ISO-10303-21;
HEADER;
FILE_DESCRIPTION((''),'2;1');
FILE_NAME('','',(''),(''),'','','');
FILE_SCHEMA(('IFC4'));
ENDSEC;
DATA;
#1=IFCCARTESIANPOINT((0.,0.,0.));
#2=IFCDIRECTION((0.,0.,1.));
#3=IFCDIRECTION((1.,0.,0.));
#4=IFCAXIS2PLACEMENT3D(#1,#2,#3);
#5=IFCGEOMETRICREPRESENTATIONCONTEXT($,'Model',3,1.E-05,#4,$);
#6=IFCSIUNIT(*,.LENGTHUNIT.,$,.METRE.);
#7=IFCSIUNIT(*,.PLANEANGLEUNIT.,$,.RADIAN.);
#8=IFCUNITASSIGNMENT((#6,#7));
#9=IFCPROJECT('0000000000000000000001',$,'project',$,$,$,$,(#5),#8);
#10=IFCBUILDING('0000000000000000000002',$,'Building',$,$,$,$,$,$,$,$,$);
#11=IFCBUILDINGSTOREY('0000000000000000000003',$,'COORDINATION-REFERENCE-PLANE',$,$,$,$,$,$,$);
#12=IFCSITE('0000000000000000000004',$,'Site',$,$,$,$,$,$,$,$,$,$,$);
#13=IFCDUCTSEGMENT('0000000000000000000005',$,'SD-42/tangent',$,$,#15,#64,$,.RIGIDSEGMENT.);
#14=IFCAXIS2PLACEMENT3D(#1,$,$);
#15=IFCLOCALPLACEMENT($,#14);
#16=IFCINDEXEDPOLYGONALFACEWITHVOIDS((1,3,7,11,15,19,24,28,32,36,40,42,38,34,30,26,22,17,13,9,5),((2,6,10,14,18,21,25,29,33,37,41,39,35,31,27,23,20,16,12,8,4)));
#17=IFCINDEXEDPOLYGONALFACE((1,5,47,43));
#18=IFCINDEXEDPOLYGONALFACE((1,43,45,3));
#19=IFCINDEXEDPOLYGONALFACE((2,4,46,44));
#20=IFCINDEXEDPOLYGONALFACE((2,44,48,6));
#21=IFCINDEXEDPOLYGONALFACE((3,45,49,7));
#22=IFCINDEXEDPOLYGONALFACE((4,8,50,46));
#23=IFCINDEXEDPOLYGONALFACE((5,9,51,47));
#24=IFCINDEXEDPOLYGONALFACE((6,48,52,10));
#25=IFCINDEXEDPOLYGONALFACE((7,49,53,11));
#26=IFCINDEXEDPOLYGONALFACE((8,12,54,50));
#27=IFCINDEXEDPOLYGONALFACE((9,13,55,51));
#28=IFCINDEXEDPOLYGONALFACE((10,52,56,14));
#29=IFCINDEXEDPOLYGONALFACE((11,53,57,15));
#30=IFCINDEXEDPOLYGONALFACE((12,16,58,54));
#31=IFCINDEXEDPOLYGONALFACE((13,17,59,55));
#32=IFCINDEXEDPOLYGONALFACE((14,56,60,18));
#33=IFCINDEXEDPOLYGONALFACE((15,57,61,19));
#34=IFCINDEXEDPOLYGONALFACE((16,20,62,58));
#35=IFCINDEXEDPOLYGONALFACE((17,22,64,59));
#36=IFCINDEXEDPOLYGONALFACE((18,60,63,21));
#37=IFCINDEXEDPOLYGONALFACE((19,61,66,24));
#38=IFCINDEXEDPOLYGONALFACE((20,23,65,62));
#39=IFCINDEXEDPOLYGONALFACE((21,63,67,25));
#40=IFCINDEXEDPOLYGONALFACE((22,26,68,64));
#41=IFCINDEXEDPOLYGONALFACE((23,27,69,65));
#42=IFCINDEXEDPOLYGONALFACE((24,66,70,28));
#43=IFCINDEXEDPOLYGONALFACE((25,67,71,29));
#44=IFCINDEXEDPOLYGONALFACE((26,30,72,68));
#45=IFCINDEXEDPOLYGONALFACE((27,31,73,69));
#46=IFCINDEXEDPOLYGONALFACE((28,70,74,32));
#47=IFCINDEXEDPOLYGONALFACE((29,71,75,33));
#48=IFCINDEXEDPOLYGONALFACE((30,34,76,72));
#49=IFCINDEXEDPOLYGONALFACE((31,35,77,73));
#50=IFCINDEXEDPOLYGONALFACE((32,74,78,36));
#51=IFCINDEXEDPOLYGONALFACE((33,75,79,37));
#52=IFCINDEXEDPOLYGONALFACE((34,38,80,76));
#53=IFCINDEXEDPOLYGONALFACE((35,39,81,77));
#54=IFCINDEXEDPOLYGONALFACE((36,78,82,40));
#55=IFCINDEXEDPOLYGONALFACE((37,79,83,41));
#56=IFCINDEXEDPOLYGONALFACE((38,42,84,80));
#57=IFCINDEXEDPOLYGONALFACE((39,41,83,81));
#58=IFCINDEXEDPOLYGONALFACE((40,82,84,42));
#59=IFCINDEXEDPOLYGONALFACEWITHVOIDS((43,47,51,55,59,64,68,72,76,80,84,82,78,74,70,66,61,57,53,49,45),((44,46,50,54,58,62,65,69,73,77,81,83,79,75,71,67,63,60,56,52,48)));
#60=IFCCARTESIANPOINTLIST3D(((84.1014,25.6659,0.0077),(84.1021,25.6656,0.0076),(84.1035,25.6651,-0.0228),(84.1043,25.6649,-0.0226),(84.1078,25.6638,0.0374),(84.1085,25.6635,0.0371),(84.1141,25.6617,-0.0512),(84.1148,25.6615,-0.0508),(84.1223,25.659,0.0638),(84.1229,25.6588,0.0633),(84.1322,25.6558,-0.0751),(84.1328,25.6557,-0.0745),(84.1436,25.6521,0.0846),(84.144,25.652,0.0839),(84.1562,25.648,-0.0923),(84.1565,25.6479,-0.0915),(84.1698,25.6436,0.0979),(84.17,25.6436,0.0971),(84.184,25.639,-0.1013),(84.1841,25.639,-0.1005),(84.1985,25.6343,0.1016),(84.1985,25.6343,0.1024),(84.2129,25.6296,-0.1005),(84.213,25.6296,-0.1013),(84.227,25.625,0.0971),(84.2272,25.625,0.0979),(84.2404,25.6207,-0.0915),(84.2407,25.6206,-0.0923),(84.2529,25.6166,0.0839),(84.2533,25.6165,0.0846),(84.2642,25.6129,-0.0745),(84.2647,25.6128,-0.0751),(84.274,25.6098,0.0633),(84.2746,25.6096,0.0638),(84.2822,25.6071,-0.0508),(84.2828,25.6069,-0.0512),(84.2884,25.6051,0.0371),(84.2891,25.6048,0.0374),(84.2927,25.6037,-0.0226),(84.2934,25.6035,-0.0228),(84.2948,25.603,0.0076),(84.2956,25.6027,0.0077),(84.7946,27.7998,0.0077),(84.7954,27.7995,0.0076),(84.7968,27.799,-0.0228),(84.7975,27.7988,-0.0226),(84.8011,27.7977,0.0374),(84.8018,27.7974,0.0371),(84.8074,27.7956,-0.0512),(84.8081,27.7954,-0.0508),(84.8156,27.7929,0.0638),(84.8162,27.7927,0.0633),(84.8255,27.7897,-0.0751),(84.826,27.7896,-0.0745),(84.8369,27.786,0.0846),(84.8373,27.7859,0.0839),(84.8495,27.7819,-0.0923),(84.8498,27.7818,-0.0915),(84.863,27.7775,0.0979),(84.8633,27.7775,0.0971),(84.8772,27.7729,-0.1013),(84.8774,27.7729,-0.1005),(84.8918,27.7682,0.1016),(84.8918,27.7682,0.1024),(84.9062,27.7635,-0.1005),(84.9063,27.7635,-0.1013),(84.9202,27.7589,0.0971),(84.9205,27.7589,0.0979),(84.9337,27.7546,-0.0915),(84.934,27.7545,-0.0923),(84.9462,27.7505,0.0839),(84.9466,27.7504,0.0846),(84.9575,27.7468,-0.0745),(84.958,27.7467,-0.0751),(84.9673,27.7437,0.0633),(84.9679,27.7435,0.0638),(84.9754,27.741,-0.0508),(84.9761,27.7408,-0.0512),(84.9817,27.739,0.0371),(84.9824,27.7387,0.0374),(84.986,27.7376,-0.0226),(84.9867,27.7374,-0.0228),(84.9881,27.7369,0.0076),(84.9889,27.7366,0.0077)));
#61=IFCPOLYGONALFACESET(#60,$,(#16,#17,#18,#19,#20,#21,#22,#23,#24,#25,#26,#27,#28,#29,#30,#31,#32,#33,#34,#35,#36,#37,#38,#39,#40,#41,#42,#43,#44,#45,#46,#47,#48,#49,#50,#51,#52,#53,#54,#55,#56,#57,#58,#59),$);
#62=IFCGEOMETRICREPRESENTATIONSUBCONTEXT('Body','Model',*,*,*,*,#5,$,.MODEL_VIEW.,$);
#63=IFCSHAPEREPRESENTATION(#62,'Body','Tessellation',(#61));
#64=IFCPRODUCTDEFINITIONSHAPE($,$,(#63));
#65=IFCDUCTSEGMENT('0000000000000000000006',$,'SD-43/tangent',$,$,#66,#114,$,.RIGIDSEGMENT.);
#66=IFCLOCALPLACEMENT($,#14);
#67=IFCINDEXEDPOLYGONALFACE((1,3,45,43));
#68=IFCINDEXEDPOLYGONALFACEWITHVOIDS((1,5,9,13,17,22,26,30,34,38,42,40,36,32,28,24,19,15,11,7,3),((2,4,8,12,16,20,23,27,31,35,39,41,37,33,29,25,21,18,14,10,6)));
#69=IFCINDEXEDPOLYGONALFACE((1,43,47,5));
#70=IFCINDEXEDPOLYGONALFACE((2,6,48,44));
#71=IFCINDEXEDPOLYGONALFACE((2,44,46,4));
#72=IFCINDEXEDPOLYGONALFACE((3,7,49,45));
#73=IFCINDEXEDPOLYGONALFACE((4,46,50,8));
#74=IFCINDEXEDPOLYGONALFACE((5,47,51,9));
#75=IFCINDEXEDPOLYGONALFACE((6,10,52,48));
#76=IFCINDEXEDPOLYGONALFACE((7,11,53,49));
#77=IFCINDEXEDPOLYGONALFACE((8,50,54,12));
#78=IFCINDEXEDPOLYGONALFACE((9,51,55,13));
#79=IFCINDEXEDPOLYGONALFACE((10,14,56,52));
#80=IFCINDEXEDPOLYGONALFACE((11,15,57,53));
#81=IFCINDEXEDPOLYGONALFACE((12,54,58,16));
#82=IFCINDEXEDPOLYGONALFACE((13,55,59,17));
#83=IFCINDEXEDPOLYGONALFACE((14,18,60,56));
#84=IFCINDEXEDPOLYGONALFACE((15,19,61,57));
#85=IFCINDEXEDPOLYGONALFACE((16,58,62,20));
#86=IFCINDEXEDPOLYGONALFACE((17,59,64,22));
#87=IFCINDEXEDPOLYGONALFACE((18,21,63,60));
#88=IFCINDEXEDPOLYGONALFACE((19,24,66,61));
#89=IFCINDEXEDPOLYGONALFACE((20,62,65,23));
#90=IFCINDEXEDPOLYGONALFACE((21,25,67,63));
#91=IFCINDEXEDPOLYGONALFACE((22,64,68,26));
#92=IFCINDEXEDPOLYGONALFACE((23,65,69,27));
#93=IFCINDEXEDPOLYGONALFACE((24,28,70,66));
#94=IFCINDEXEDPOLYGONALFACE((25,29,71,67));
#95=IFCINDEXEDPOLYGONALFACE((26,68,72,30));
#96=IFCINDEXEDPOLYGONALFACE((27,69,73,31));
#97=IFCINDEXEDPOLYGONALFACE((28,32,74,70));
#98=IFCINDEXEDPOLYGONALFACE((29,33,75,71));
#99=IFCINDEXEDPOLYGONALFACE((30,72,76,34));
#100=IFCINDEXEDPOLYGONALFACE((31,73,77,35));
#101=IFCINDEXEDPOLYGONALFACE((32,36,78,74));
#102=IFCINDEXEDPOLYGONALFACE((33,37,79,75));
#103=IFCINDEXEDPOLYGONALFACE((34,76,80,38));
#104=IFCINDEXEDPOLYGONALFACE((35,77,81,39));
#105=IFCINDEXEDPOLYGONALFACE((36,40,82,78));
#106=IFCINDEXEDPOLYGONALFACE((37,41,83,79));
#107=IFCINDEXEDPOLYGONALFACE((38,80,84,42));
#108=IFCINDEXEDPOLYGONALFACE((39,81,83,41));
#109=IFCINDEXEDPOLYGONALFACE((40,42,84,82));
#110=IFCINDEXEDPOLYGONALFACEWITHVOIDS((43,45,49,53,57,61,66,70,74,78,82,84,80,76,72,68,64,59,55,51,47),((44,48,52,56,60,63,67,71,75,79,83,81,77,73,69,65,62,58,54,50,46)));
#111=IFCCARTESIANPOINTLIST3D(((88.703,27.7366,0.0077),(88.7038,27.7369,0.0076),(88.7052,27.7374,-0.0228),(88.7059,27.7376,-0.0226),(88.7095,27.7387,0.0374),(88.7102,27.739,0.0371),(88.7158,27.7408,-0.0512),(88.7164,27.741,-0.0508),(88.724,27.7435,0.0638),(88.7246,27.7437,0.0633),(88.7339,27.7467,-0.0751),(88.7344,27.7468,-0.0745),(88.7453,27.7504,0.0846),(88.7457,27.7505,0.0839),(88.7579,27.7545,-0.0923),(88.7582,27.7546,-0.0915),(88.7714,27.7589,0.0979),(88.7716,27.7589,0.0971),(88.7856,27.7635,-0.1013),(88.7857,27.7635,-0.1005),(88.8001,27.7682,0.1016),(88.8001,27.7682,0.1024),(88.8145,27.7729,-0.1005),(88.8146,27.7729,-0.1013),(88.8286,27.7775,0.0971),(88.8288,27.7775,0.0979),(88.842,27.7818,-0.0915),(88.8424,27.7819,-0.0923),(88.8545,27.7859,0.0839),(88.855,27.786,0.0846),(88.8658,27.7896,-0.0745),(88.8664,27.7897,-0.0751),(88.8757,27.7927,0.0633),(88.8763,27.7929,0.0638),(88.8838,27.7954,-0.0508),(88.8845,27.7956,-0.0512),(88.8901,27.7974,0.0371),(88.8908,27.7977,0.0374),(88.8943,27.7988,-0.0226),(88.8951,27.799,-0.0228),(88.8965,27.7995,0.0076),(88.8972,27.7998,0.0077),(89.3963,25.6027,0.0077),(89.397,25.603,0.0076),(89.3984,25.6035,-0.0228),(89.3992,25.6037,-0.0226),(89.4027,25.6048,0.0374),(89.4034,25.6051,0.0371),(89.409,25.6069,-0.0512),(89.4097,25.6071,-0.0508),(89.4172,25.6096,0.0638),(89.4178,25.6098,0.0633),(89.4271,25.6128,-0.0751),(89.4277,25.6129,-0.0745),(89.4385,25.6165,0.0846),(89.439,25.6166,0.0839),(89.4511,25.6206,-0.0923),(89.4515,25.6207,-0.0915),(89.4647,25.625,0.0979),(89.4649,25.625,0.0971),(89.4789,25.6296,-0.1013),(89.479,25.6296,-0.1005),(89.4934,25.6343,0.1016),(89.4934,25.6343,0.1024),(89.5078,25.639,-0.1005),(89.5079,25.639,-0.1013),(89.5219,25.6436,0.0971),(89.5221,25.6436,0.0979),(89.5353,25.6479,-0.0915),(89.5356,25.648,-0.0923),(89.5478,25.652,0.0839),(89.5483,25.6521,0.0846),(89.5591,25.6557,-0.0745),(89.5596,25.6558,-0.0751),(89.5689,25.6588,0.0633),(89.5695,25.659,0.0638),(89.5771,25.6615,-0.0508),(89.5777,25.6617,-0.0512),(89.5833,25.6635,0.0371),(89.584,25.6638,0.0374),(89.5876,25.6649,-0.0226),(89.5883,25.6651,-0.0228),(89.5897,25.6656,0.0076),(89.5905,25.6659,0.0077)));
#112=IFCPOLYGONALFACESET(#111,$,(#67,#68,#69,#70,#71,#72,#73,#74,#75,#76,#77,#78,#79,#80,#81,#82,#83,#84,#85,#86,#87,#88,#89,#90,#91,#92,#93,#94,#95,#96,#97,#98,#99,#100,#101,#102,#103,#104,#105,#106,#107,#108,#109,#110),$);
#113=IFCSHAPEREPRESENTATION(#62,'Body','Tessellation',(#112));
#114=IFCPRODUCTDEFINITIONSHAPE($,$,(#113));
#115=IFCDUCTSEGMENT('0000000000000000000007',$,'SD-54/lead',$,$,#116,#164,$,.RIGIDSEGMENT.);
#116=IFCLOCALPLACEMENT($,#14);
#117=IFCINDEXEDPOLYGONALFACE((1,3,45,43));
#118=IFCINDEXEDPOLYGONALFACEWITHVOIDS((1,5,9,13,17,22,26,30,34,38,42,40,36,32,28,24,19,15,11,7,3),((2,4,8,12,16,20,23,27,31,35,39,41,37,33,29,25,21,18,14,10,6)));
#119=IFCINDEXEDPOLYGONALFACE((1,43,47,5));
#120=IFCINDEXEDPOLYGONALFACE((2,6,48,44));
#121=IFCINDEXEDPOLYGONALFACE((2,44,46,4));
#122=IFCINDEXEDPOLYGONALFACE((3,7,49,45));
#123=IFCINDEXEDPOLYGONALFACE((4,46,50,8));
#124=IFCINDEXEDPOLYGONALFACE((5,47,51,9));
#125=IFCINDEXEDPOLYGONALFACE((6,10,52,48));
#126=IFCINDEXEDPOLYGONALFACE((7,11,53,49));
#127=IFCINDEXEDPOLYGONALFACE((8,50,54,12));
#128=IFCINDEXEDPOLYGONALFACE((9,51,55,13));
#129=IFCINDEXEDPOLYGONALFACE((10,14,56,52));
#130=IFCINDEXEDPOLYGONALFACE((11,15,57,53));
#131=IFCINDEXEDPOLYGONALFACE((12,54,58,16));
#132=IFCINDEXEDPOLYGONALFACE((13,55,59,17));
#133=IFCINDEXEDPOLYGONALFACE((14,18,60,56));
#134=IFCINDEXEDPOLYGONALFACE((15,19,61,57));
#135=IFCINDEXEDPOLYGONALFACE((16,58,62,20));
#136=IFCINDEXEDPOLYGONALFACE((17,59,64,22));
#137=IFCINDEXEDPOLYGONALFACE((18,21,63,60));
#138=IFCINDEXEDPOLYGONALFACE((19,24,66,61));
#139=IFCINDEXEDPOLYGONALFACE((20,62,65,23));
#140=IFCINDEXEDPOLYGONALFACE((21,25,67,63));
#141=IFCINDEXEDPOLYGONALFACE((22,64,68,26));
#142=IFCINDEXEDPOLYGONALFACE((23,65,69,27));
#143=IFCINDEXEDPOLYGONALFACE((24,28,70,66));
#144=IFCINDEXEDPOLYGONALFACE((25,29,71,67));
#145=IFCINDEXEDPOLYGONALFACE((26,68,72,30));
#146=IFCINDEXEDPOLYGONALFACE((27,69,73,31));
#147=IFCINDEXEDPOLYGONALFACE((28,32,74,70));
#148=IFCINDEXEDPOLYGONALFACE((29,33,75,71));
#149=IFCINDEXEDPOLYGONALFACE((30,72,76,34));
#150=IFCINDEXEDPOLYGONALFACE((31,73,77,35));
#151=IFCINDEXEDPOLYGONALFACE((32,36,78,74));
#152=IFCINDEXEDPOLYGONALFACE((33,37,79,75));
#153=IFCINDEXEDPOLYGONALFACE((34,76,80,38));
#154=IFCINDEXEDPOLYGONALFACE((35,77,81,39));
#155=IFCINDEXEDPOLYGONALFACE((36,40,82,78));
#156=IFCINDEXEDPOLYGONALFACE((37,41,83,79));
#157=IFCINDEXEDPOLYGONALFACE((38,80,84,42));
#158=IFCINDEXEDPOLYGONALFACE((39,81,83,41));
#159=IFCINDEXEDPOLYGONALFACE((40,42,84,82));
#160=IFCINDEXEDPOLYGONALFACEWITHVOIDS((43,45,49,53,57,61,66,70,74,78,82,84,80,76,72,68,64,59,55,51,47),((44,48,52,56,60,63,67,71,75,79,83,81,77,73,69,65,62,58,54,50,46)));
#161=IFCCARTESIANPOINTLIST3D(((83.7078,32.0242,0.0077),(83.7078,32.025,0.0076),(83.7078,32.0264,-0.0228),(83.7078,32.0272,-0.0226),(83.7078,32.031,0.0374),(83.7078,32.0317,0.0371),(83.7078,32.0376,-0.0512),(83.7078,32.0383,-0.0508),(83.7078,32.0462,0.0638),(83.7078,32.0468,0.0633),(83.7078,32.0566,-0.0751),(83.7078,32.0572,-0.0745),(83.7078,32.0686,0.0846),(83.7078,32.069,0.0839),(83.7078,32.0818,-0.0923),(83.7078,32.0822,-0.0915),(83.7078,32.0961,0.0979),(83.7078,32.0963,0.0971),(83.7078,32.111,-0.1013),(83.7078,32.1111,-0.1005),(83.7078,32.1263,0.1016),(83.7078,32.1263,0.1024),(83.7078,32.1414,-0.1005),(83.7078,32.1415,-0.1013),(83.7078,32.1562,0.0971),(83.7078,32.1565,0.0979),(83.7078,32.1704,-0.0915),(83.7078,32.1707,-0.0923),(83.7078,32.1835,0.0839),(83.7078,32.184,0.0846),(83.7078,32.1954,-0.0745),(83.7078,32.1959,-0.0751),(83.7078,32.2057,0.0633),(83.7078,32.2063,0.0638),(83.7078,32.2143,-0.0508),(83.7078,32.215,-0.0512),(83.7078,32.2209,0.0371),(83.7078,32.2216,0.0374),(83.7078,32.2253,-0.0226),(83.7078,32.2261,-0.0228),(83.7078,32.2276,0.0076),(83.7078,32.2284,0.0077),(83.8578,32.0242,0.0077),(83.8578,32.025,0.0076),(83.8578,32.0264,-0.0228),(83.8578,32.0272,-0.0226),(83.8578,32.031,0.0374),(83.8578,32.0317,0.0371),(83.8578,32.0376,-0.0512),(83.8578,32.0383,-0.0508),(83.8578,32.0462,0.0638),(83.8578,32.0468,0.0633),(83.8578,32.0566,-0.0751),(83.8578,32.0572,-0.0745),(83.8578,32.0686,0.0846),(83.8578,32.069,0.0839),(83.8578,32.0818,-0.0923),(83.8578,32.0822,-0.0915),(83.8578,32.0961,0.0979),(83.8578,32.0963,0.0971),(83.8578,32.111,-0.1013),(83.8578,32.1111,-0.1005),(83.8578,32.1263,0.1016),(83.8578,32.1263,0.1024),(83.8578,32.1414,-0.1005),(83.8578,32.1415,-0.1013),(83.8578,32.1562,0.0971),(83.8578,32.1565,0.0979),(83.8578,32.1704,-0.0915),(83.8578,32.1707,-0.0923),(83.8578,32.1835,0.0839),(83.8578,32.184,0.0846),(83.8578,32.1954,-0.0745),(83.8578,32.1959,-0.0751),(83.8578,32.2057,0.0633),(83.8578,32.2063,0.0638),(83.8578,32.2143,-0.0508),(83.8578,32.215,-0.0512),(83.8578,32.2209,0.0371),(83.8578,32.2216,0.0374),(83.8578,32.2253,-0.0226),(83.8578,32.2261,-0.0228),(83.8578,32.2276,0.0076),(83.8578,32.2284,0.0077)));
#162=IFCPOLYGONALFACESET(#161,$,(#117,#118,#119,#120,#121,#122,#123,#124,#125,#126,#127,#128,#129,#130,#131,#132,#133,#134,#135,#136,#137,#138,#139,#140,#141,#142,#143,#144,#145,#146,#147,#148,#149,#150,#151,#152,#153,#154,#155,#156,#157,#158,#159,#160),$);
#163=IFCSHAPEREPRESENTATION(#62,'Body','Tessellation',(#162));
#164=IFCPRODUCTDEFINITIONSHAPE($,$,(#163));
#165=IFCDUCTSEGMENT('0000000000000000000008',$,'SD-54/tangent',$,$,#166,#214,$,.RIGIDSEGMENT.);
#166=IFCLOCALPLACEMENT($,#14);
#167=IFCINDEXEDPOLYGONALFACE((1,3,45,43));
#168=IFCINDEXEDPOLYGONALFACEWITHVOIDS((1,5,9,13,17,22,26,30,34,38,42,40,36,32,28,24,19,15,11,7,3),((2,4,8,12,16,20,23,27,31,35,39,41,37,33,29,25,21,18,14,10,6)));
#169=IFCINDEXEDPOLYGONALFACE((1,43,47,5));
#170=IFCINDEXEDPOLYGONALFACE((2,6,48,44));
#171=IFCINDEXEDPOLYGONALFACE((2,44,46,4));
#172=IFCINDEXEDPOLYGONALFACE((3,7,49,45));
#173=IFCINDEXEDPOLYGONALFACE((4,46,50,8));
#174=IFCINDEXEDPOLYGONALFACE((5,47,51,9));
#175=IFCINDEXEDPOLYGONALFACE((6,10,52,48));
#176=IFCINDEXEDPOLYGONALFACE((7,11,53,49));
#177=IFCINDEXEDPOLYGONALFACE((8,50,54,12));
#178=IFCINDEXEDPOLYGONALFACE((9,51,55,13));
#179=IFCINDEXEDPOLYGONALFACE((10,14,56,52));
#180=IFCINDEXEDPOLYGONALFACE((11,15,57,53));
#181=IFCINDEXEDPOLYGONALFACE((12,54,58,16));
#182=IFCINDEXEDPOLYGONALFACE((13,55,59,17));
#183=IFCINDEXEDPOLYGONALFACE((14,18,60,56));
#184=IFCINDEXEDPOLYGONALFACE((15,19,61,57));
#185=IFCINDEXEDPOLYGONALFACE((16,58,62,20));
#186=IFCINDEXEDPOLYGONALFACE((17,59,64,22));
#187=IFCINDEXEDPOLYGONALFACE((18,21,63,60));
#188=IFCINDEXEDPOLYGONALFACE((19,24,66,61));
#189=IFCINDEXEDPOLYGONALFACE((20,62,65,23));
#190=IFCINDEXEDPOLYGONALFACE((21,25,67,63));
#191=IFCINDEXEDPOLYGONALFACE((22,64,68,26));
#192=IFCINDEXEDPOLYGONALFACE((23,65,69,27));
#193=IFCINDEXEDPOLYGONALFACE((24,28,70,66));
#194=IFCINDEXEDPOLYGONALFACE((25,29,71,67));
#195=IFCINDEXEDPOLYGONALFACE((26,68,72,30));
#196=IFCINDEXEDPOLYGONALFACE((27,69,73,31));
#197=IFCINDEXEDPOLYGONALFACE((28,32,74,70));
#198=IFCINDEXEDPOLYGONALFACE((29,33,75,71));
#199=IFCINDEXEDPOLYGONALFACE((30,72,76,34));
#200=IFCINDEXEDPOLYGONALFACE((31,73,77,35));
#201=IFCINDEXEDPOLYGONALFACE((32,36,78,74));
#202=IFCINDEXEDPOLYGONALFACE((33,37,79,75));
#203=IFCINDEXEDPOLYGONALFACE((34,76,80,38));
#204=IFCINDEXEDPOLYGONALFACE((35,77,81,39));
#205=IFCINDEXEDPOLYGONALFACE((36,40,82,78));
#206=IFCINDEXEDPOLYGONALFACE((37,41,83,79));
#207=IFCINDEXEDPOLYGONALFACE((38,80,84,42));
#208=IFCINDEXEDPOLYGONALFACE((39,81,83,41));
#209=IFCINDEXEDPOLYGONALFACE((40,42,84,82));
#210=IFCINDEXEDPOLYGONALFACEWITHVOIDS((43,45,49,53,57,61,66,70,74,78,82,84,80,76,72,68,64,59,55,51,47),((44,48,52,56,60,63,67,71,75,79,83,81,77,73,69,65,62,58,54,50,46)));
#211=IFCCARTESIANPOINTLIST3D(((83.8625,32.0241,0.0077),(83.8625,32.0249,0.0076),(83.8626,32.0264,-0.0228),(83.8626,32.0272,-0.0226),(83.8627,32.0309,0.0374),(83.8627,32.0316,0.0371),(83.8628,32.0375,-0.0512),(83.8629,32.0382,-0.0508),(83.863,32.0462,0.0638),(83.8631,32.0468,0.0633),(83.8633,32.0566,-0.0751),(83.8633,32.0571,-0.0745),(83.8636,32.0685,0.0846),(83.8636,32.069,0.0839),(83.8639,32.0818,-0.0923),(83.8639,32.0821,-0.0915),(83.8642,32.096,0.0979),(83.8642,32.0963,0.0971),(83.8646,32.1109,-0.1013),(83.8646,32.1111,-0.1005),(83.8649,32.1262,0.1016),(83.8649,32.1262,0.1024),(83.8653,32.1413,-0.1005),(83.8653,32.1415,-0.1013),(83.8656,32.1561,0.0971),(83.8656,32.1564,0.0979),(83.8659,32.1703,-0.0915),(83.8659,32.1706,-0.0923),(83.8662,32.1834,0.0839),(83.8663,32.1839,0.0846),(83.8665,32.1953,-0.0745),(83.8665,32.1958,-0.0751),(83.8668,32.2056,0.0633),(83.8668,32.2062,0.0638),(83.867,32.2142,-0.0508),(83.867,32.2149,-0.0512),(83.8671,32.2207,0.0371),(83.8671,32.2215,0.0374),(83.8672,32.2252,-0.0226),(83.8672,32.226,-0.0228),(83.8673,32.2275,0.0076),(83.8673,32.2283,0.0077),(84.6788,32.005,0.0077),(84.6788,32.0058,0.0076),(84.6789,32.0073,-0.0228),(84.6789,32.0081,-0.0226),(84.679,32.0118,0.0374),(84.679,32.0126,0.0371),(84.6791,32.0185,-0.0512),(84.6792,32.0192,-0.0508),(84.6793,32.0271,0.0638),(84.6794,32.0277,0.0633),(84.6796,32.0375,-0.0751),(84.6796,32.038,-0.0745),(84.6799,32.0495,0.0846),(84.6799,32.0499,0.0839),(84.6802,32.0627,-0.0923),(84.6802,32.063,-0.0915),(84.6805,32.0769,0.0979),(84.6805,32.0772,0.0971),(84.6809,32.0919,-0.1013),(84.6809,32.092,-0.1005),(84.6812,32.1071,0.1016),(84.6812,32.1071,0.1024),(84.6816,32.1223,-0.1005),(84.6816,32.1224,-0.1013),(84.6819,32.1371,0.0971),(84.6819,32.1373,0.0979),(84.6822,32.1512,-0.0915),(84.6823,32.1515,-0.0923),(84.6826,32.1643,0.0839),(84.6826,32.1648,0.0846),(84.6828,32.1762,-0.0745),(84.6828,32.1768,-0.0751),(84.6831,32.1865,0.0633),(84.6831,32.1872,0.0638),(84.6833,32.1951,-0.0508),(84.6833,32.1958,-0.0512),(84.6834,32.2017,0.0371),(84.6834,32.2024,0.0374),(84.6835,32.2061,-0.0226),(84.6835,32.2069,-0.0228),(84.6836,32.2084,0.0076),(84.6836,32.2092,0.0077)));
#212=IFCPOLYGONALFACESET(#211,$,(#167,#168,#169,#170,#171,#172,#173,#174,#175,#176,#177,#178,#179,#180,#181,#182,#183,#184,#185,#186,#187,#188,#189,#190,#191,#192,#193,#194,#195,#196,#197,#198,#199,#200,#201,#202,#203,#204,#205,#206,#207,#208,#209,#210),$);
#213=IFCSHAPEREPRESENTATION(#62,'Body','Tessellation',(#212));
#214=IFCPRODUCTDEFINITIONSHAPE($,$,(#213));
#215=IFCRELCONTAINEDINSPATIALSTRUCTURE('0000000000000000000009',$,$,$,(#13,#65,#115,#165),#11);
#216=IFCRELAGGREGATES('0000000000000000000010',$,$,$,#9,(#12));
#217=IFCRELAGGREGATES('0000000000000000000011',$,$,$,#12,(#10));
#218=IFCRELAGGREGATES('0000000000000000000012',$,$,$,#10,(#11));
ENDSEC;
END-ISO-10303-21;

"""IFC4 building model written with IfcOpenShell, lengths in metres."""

from ifc_helpers import new_model, si_unit, frame, origin_with_axes, place, context, subcontext, project, spatial, hollow_circle, extrude, element, save


model = new_model("IFC4")

# Units and contexts
model_context = context("Model", 3, precision=1e-05, world=origin_with_axes())
body_context_1 = subcontext(model_context, "Body", "Model", "MODEL_VIEW")
ifc_project = project(units=[si_unit("LENGTHUNIT", "METRE"), si_unit("PLANEANGLEUNIT", "RADIAN")], contexts=[model_context])

# Site, building, storey
site = spatial("IfcSite", under=ifc_project, Name="Site")
building = spatial("IfcBuilding", under=site, Name="Building")
storey = spatial("IfcBuildingStorey", under=building, Name="COORDINATION-REFERENCE-PLANE")

# Duct segment
duct_segment_1_placement = place(None, frame((84.1985, 25.6343, 0.0), z_axis=(0.30899, 0.951065, 0.0), x_axis=(0.0, 0.0, 1.0)))
element("IfcDuctSegment", 1, at=duct_segment_1_placement, inside=storey, Name="SD-42/tangent", PredefinedType="RIGIDSEGMENT", context=body_context_1, shape_type="SweptSolid", body=[
    extrude(hollow_circle(Radius=0.1024, WallThickness=0.0008), origin_with_axes(), (0.0, 0.0, 1.0), 2.2437),
])

# Duct segment
duct_segment_2_placement = place(None, frame((89.4934, 25.6343, 0.0), z_axis=(-0.30899, 0.951065, 0.0), x_axis=(0.0, 0.0, 1.0)))
element("IfcDuctSegment", 2, at=duct_segment_2_placement, inside=storey, Name="SD-43/tangent", PredefinedType="RIGIDSEGMENT", context=body_context_1, shape_type="SweptSolid", body=[
    extrude(hollow_circle(Radius=0.1024, WallThickness=0.0008), origin_with_axes(), (0.0, 0.0, 1.0), 2.2437),
])

# Duct segment
duct_segment_3_placement = place(None, frame((83.7078, 32.1263, 0.0), z_axis=(1.0, 0.0, 0.0), x_axis=(0.0, 0.0, 1.0)))
element("IfcDuctSegment", 3, at=duct_segment_3_placement, inside=storey, Name="SD-54/lead", PredefinedType="RIGIDSEGMENT", context=body_context_1, shape_type="SweptSolid", body=[
    extrude(hollow_circle(Radius=0.1024, WallThickness=0.0008), origin_with_axes(), (0.0, 0.0, 1.0), 0.15),
])

# Duct segment
duct_segment_4_placement = place(None, frame((83.8649, 32.1262, 0.0), z_axis=(0.999727, -0.023361, 0.0), x_axis=(0.0, 0.0, 1.0)))
element("IfcDuctSegment", 4, at=duct_segment_4_placement, inside=storey, Name="SD-54/tangent", PredefinedType="RIGIDSEGMENT", context=body_context_1, shape_type="SweptSolid", body=[
    extrude(hollow_circle(Radius=0.1024, WallThickness=0.0008), origin_with_axes(), (0.0, 0.0, 1.0), 0.8165),
])

save(model, "model.ifc")
